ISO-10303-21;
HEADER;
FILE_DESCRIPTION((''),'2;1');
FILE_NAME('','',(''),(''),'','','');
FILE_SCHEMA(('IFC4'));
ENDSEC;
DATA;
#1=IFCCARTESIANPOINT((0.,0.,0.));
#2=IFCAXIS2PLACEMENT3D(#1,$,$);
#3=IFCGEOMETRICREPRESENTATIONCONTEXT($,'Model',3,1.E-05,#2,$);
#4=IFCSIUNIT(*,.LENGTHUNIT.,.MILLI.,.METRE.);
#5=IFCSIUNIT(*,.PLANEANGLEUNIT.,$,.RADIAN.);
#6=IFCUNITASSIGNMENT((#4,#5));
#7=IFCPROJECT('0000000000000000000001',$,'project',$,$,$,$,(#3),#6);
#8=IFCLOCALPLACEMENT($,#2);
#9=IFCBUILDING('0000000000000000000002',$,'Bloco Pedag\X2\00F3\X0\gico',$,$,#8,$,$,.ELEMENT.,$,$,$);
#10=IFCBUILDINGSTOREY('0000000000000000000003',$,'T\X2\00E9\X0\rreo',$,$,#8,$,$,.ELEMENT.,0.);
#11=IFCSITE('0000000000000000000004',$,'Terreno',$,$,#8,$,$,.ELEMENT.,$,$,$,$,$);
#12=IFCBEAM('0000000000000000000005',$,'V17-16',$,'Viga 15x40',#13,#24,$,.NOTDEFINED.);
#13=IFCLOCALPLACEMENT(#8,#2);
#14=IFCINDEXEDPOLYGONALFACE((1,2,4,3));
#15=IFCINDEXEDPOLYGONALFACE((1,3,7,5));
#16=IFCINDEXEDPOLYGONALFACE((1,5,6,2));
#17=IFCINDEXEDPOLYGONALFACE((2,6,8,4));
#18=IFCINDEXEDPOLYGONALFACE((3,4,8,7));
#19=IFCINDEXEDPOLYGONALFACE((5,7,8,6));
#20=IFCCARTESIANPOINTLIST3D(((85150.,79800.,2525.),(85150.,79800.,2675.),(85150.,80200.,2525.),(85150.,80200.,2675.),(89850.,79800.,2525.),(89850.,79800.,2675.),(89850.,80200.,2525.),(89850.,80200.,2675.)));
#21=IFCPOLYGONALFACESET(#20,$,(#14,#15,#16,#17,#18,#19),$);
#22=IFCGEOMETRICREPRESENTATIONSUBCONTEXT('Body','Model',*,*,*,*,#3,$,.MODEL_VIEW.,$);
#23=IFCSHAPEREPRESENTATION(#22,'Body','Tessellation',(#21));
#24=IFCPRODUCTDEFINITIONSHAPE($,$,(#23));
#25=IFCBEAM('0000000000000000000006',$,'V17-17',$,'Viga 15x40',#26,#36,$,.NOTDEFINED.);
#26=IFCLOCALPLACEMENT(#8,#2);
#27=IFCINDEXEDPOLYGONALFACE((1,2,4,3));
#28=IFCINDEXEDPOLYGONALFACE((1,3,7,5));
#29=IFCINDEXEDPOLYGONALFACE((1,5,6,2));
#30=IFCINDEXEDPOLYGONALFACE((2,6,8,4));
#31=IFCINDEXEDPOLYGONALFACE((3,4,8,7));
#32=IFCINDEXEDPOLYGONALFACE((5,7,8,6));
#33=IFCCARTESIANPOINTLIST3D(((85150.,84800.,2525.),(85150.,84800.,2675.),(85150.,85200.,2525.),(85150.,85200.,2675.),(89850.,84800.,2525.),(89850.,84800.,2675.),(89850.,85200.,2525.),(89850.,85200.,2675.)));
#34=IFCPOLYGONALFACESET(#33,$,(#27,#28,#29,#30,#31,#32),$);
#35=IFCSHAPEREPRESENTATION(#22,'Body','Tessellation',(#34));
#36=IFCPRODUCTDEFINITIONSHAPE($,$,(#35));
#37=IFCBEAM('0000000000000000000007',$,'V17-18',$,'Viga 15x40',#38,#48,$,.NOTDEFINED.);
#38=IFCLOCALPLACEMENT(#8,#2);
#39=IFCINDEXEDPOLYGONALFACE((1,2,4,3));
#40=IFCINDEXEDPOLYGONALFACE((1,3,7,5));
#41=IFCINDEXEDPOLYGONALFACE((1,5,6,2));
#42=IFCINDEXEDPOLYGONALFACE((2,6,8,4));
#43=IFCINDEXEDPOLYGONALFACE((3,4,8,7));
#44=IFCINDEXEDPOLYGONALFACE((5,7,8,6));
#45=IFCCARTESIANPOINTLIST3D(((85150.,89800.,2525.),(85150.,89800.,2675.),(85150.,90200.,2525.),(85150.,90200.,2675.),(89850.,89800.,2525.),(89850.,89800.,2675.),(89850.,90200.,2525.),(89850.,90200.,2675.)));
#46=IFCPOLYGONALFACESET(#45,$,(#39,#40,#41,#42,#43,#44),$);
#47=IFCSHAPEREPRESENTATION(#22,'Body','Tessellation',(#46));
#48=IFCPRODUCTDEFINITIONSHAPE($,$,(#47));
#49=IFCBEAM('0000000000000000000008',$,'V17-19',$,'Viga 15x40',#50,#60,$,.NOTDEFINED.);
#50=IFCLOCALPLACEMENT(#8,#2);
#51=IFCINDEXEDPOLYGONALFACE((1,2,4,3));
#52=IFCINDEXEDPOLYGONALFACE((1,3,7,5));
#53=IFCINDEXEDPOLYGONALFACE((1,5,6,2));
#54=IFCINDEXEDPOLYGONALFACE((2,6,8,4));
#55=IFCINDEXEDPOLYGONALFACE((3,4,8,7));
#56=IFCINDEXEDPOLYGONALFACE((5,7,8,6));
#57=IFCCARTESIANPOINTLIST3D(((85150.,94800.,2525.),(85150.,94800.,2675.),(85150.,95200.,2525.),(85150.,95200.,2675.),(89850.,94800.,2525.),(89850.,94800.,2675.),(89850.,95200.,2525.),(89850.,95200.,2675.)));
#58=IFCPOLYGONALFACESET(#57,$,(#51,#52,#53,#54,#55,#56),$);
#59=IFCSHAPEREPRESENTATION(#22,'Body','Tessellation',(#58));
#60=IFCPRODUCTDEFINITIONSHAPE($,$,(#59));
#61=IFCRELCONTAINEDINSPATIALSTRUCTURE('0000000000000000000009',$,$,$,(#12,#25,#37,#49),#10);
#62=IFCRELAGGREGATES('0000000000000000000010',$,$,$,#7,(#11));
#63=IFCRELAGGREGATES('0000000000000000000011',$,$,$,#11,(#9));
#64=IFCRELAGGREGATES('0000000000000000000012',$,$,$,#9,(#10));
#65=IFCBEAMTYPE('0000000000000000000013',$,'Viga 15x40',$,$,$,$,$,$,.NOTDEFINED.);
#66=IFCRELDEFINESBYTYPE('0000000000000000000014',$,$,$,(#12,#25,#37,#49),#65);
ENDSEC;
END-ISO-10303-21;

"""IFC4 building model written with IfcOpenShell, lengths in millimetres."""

from ifc_helpers import new_model, si_unit, frame, origin, origin_2d, place, context, subcontext, project, spatial, rectangle, extrude, type_object, element, save


model = new_model("IFC4")

# Units and contexts
model_context = context("Model", 3, precision=1e-05, world=origin())
body_context = subcontext(model_context, "Body", "Model", "MODEL_VIEW")
ifc_project = project(units=[si_unit("LENGTHUNIT", "METRE", prefix="MILLI"), si_unit("PLANEANGLEUNIT", "RADIAN")], contexts=[model_context])

# Site, building, storey
placement = place(None, origin())
site = spatial("IfcSite", under=ifc_project, at=placement, Name="Terreno", CompositionType="ELEMENT")
building = spatial("IfcBuilding", under=site, at=placement, Name="Bloco Pedagógico", CompositionType="ELEMENT")
storey = spatial("IfcBuildingStorey", under=building, at=placement, Name="Térreo", CompositionType="ELEMENT", Elevation=0.0)

# Beams
beam_type = type_object("IfcBeamType", Name="Viga 15x40", PredefinedType="NOTDEFINED")
for number, where, z_axis, x_axis, name in (
    (1, (85150.0, 80000.0, 2600.0), (1.0, 0.0, 0.0), (0.0, 1.0, 0.0), "V17-16"),
    (2, (85150.0, 85000.0, 2600.0), (1.0, 0.0, 0.0), (0.0, 1.0, 0.0), "V17-17"),
    (3, (85150.0, 90000.0, 2600.0), (1.0, 0.0, 0.0), (0.0, 1.0, 0.0), "V17-18"),
    (4, (85150.0, 95000.0, 2600.0), (1.0, 0.0, 0.0), (0.0, 1.0, 0.0), "V17-19"),
):
    element("IfcBeam", number, at=place(None, frame(where, z_axis=z_axis, x_axis=x_axis)), inside=storey, type_object=beam_type, Name=name, ObjectType="Viga 15x40", PredefinedType="NOTDEFINED", context=body_context, shape_type="SweptSolid", body=[
        extrude(rectangle(XDim=400.0, YDim=150.0, at=origin_2d()), None, (0.0, 0.0, 1.0), 4700.0),
    ])

save(model, "model.ifc")
